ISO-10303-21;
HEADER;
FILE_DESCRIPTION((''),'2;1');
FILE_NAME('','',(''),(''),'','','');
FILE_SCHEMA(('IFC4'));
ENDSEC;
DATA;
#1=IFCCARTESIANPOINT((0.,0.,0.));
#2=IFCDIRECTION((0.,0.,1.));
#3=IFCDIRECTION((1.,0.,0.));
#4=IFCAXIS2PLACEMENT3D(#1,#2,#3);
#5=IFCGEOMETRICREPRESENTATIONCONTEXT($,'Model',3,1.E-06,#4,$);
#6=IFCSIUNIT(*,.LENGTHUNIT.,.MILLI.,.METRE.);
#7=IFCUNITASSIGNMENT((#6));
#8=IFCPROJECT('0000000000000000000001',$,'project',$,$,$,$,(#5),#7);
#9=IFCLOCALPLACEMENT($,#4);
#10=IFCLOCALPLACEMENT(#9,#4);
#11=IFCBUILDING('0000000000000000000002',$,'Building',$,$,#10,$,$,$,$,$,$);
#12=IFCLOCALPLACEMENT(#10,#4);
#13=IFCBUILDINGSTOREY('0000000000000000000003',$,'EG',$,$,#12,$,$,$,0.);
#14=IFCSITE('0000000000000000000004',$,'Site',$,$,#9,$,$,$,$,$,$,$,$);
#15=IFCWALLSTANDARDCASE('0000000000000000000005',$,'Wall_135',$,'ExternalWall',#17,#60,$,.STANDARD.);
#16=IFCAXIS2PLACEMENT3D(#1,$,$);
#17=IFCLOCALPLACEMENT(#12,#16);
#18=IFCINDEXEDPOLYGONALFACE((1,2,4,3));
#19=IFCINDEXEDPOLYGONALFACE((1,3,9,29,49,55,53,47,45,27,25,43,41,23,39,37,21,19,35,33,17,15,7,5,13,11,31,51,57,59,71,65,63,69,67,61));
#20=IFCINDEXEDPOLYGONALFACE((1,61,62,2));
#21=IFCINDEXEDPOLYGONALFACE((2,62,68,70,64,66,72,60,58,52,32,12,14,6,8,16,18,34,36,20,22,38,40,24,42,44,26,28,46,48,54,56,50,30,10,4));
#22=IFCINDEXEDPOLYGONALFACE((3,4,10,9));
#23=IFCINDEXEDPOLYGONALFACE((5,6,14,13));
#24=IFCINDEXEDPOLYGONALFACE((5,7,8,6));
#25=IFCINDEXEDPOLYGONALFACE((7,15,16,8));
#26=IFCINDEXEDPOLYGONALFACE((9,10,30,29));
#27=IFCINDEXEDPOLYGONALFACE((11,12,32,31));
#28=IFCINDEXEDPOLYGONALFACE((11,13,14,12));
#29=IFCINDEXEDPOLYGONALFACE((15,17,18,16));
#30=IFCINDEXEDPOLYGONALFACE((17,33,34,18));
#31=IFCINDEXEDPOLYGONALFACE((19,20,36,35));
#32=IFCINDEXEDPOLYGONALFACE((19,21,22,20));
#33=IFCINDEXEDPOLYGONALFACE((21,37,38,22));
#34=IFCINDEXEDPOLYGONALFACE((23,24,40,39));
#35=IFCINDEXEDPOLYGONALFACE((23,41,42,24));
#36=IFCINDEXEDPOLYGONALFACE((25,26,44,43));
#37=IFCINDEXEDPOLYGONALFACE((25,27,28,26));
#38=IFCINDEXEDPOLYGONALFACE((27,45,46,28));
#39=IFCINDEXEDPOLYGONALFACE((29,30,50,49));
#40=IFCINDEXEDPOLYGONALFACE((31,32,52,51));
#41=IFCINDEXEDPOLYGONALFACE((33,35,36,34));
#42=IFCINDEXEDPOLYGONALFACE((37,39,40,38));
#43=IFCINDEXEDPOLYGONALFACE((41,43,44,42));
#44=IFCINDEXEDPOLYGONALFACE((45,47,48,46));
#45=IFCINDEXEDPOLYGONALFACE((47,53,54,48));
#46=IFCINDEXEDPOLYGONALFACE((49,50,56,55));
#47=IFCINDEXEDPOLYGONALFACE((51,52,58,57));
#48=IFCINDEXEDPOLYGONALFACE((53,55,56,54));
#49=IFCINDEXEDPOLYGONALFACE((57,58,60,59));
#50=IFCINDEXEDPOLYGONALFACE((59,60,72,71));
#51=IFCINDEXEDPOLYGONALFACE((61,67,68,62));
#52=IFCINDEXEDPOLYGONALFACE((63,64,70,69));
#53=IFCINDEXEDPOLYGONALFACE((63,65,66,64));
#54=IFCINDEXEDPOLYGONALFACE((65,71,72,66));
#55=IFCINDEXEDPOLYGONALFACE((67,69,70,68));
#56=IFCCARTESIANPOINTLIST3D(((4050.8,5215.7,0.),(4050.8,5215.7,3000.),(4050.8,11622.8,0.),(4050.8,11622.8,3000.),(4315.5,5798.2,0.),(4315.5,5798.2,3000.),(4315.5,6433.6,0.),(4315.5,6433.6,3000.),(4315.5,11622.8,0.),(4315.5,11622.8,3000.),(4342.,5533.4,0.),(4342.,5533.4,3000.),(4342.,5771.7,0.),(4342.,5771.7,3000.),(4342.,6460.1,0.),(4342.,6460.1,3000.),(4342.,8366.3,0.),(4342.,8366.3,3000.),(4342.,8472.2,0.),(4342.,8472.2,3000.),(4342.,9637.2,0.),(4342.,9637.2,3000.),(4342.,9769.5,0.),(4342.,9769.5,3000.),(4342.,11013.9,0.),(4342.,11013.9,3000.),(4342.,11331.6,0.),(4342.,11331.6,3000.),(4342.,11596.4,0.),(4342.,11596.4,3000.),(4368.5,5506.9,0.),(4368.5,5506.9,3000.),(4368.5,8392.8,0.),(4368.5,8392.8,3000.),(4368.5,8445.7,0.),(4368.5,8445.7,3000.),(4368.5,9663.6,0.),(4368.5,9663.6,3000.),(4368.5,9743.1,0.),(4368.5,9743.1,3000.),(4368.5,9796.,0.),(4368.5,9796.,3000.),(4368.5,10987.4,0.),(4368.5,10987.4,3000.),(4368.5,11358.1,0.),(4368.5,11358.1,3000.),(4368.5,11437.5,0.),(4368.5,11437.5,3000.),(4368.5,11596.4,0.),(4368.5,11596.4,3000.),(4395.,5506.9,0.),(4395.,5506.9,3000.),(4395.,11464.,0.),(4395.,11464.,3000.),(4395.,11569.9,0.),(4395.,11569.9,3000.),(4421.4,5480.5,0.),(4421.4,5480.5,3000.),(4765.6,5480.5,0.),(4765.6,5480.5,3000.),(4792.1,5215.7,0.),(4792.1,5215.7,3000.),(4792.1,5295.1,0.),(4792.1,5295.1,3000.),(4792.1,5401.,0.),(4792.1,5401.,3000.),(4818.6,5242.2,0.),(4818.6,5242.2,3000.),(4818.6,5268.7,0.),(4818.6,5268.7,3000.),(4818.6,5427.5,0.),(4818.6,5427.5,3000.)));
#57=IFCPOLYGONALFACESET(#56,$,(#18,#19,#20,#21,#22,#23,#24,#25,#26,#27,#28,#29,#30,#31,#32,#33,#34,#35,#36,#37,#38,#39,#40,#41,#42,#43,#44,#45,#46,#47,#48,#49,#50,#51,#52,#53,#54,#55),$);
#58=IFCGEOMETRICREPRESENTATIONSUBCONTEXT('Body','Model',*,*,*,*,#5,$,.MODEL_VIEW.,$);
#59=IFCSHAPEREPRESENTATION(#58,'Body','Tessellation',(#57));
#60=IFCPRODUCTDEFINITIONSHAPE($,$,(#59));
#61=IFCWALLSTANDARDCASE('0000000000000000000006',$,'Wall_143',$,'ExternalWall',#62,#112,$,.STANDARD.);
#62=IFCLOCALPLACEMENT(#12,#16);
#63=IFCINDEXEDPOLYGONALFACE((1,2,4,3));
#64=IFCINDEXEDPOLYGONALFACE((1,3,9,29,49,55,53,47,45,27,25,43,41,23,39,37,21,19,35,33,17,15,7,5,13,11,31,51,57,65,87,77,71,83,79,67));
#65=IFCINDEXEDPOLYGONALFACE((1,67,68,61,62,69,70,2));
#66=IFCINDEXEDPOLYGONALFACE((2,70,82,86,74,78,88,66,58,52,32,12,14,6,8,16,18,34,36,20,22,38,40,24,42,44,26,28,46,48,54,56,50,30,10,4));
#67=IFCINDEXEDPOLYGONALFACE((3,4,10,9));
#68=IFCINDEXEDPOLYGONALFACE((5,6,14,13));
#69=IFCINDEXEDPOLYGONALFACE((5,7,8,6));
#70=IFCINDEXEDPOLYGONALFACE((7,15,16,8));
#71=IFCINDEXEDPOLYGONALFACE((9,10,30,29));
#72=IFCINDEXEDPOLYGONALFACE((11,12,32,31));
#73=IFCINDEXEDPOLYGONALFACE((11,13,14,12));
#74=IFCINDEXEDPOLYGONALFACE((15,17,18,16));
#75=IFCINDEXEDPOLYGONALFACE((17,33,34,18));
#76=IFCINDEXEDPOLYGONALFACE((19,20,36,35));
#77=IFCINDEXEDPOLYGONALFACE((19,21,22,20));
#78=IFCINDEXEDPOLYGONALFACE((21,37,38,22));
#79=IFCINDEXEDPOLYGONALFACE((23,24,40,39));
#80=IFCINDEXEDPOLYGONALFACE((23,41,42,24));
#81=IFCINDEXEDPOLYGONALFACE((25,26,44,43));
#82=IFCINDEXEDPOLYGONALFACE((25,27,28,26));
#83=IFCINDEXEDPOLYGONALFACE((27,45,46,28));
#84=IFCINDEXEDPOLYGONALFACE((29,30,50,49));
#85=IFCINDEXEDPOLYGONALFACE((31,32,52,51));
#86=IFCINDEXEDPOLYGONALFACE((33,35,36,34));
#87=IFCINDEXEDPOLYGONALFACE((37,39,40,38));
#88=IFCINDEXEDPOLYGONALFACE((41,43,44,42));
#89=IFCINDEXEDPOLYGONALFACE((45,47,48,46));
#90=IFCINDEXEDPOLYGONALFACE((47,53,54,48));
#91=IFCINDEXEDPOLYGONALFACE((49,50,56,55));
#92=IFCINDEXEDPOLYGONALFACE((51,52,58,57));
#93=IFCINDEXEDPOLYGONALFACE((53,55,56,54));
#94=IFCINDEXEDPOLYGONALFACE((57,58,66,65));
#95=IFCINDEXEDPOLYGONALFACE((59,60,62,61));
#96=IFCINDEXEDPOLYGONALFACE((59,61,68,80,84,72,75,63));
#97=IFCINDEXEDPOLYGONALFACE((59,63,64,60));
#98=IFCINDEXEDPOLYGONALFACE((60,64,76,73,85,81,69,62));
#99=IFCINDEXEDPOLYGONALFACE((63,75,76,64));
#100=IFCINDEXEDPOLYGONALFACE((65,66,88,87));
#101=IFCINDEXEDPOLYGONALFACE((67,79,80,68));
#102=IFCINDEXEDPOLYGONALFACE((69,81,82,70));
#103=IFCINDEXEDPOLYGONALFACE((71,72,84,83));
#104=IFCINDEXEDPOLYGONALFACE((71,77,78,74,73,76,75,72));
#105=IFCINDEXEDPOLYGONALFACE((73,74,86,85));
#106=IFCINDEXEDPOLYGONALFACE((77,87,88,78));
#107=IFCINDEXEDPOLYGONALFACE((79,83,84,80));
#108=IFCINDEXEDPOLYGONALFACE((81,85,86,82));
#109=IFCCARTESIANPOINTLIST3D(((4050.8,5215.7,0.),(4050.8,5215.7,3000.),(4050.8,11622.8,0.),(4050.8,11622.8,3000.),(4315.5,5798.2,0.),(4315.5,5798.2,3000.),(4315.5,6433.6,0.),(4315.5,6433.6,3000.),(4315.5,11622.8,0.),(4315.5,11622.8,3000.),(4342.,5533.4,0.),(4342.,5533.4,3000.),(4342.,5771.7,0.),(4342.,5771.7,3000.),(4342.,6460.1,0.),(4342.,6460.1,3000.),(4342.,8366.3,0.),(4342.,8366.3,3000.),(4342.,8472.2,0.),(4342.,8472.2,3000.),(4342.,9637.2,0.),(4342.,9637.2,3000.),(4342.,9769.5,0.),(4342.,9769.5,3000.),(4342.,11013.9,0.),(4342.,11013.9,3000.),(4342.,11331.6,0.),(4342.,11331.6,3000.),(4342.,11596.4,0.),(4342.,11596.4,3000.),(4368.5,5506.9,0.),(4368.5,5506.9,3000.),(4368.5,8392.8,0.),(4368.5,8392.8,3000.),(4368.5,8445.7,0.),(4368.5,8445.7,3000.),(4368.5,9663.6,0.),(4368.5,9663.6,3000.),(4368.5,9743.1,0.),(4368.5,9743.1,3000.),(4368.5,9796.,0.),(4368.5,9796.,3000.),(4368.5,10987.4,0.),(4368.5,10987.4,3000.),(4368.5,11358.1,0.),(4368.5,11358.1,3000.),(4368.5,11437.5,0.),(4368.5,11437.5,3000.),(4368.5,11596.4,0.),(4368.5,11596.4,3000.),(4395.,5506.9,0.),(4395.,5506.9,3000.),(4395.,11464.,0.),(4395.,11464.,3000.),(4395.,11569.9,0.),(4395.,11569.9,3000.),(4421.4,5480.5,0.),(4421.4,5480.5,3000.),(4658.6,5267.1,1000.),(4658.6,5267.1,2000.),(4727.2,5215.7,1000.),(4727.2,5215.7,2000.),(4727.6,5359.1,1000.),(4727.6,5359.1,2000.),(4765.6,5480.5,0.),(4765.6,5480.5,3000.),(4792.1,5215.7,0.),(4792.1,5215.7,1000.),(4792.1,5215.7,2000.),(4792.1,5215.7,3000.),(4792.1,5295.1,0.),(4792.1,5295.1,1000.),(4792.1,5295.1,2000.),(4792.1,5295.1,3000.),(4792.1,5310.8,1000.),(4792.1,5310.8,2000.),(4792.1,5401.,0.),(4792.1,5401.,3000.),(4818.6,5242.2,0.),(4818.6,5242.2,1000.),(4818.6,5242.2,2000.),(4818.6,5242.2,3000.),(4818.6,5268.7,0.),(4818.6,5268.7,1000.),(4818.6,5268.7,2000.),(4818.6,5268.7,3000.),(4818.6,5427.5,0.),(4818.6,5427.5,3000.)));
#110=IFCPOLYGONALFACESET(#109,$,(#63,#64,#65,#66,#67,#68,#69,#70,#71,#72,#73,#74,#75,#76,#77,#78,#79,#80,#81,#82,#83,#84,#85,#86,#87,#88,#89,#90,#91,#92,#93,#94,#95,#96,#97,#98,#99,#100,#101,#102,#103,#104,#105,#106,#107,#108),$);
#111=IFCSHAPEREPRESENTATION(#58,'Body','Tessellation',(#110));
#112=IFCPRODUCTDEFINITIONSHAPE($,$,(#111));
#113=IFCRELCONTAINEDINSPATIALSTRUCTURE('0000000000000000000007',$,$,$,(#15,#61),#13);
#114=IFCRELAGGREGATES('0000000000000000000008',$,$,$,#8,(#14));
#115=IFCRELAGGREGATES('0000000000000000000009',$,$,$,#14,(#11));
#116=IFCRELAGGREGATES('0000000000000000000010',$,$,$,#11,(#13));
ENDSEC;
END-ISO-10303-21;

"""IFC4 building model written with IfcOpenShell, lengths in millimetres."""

from ifc_helpers import new_model, si_unit, frame, origin_with_axes, place, context, subcontext, project, spatial, polyline, rectangle, outline, extrude, element, save


model = new_model("IFC4")

# Units and contexts
model_context = context("Model", 3, precision=1e-06, world=origin_with_axes())
body_context = subcontext(model_context, "Body", "Model", "MODEL_VIEW")
ifc_project = project(units=[si_unit("LENGTHUNIT", "METRE", prefix="MILLI")], contexts=[model_context])

# Site, building, storey
site_placement = place(None, origin_with_axes())
site = spatial("IfcSite", under=ifc_project, at=site_placement, Name="Site")
building_placement = place(site_placement, origin_with_axes())
building = spatial("IfcBuilding", under=site, at=building_placement, Name="Building")
storey_placement = place(building_placement, origin_with_axes())
storey = spatial("IfcBuildingStorey", under=building, at=storey_placement, Name="EG", Elevation=0.0)

# Wall
for number, where, z_axis, x_axis, name in (
    (1, (0.0, 0.0, 0.0), (0.0, 0.0, 1.0), (1.0, 0.0, 0.0), "Wall_135"),
):
    element("IfcWallStandardCase", number, at=place(storey_placement, frame(where, z_axis=z_axis, x_axis=x_axis)), inside=storey, Name=name, ObjectType="ExternalWall", PredefinedType="STANDARD", context=body_context, shape_type="SweptSolid", body=[
        extrude(outline(polyline([(4050.8, 5215.7, 0.0), (4050.8, 11622.8, 0.0), (4315.5, 11622.8, 0.0), (4342.0, 11596.4, 0.0), (4368.5, 11596.4, 0.0), (4395.0, 11569.9, 0.0), (4395.0, 11464.0, 0.0), (4368.5, 11437.5, 0.0), (4368.5, 11358.1, 0.0), (4342.0, 11331.6, 0.0), (4342.0, 11013.9, 0.0), (4368.5, 10987.4, 0.0), (4368.5, 9796.0, 0.0), (4342.0, 9769.5, 0.0), (4368.5, 9743.1, 0.0), (4368.5, 9663.6, 0.0), (4342.0, 9637.2, 0.0), (4342.0, 8472.2, 0.0), (4368.5, 8445.7, 0.0), (4368.5, 8392.8, 0.0), (4342.0, 8366.3, 0.0), (4342.0, 6460.1, 0.0), (4315.5, 6433.6, 0.0), (4315.5, 5798.2, 0.0), (4342.0, 5771.7, 0.0), (4342.0, 5533.4, 0.0), (4368.5, 5506.9, 0.0), (4395.0, 5506.9, 0.0), (4421.4, 5480.5, 0.0), (4765.6, 5480.5, 0.0), (4818.6, 5427.5, 0.0), (4792.1, 5401.0, 0.0), (4792.1, 5295.1, 0.0), (4818.6, 5268.7, 0.0), (4818.6, 5242.2, 0.0), (4792.1, 5215.7, 0.0), (4050.8, 5215.7, 0.0)])), origin_with_axes(), (0.0, 0.0, 1.0), 3000.0),
    ])

# Wall, opening
wall_1_placement = place(storey_placement, origin_with_axes())
wall_1 = element("IfcWallStandardCase", 2, at=wall_1_placement, inside=storey, Name="Wall_143", ObjectType="ExternalWall", PredefinedType="STANDARD", context=body_context, shape_type="SweptSolid", body=[
    extrude(outline(polyline([(4050.8, 5215.7, 0.0), (4050.8, 11622.8, 0.0), (4315.5, 11622.8, 0.0), (4342.0, 11596.4, 0.0), (4368.5, 11596.4, 0.0), (4395.0, 11569.9, 0.0), (4395.0, 11464.0, 0.0), (4368.5, 11437.5, 0.0), (4368.5, 11358.1, 0.0), (4342.0, 11331.6, 0.0), (4342.0, 11013.9, 0.0), (4368.5, 10987.4, 0.0), (4368.5, 9796.0, 0.0), (4342.0, 9769.5, 0.0), (4368.5, 9743.1, 0.0), (4368.5, 9663.6, 0.0), (4342.0, 9637.2, 0.0), (4342.0, 8472.2, 0.0), (4368.5, 8445.7, 0.0), (4368.5, 8392.8, 0.0), (4342.0, 8366.3, 0.0), (4342.0, 6460.1, 0.0), (4315.5, 6433.6, 0.0), (4315.5, 5798.2, 0.0), (4342.0, 5771.7, 0.0), (4342.0, 5533.4, 0.0), (4368.5, 5506.9, 0.0), (4395.0, 5506.9, 0.0), (4421.4, 5480.5, 0.0), (4765.6, 5480.5, 0.0), (4818.6, 5427.5, 0.0), (4792.1, 5401.0, 0.0), (4792.1, 5295.1, 0.0), (4818.6, 5268.7, 0.0), (4818.6, 5242.2, 0.0), (4792.1, 5215.7, 0.0), (4050.8, 5215.7, 0.0)])), origin_with_axes(), (0.0, 0.0, 1.0), 3000.0),
])
opening_1_placement = place(wall_1_placement, origin_with_axes())
element("IfcOpeningElement", 3, at=opening_1_placement, inside=storey, cuts=wall_1, context=body_context, shape_type="SweptSolid", body=[
    extrude(rectangle(XDim=2721.7, YDim=115.0), frame((5781.8, 4496.6, 1000.0), z_axis=(0.0, 0.0, 1.0), x_axis=(0.8, -0.6, 0.0)), (0.0, 0.0, 1.0), 1000.0),
])

save(model, "model.ifc")
